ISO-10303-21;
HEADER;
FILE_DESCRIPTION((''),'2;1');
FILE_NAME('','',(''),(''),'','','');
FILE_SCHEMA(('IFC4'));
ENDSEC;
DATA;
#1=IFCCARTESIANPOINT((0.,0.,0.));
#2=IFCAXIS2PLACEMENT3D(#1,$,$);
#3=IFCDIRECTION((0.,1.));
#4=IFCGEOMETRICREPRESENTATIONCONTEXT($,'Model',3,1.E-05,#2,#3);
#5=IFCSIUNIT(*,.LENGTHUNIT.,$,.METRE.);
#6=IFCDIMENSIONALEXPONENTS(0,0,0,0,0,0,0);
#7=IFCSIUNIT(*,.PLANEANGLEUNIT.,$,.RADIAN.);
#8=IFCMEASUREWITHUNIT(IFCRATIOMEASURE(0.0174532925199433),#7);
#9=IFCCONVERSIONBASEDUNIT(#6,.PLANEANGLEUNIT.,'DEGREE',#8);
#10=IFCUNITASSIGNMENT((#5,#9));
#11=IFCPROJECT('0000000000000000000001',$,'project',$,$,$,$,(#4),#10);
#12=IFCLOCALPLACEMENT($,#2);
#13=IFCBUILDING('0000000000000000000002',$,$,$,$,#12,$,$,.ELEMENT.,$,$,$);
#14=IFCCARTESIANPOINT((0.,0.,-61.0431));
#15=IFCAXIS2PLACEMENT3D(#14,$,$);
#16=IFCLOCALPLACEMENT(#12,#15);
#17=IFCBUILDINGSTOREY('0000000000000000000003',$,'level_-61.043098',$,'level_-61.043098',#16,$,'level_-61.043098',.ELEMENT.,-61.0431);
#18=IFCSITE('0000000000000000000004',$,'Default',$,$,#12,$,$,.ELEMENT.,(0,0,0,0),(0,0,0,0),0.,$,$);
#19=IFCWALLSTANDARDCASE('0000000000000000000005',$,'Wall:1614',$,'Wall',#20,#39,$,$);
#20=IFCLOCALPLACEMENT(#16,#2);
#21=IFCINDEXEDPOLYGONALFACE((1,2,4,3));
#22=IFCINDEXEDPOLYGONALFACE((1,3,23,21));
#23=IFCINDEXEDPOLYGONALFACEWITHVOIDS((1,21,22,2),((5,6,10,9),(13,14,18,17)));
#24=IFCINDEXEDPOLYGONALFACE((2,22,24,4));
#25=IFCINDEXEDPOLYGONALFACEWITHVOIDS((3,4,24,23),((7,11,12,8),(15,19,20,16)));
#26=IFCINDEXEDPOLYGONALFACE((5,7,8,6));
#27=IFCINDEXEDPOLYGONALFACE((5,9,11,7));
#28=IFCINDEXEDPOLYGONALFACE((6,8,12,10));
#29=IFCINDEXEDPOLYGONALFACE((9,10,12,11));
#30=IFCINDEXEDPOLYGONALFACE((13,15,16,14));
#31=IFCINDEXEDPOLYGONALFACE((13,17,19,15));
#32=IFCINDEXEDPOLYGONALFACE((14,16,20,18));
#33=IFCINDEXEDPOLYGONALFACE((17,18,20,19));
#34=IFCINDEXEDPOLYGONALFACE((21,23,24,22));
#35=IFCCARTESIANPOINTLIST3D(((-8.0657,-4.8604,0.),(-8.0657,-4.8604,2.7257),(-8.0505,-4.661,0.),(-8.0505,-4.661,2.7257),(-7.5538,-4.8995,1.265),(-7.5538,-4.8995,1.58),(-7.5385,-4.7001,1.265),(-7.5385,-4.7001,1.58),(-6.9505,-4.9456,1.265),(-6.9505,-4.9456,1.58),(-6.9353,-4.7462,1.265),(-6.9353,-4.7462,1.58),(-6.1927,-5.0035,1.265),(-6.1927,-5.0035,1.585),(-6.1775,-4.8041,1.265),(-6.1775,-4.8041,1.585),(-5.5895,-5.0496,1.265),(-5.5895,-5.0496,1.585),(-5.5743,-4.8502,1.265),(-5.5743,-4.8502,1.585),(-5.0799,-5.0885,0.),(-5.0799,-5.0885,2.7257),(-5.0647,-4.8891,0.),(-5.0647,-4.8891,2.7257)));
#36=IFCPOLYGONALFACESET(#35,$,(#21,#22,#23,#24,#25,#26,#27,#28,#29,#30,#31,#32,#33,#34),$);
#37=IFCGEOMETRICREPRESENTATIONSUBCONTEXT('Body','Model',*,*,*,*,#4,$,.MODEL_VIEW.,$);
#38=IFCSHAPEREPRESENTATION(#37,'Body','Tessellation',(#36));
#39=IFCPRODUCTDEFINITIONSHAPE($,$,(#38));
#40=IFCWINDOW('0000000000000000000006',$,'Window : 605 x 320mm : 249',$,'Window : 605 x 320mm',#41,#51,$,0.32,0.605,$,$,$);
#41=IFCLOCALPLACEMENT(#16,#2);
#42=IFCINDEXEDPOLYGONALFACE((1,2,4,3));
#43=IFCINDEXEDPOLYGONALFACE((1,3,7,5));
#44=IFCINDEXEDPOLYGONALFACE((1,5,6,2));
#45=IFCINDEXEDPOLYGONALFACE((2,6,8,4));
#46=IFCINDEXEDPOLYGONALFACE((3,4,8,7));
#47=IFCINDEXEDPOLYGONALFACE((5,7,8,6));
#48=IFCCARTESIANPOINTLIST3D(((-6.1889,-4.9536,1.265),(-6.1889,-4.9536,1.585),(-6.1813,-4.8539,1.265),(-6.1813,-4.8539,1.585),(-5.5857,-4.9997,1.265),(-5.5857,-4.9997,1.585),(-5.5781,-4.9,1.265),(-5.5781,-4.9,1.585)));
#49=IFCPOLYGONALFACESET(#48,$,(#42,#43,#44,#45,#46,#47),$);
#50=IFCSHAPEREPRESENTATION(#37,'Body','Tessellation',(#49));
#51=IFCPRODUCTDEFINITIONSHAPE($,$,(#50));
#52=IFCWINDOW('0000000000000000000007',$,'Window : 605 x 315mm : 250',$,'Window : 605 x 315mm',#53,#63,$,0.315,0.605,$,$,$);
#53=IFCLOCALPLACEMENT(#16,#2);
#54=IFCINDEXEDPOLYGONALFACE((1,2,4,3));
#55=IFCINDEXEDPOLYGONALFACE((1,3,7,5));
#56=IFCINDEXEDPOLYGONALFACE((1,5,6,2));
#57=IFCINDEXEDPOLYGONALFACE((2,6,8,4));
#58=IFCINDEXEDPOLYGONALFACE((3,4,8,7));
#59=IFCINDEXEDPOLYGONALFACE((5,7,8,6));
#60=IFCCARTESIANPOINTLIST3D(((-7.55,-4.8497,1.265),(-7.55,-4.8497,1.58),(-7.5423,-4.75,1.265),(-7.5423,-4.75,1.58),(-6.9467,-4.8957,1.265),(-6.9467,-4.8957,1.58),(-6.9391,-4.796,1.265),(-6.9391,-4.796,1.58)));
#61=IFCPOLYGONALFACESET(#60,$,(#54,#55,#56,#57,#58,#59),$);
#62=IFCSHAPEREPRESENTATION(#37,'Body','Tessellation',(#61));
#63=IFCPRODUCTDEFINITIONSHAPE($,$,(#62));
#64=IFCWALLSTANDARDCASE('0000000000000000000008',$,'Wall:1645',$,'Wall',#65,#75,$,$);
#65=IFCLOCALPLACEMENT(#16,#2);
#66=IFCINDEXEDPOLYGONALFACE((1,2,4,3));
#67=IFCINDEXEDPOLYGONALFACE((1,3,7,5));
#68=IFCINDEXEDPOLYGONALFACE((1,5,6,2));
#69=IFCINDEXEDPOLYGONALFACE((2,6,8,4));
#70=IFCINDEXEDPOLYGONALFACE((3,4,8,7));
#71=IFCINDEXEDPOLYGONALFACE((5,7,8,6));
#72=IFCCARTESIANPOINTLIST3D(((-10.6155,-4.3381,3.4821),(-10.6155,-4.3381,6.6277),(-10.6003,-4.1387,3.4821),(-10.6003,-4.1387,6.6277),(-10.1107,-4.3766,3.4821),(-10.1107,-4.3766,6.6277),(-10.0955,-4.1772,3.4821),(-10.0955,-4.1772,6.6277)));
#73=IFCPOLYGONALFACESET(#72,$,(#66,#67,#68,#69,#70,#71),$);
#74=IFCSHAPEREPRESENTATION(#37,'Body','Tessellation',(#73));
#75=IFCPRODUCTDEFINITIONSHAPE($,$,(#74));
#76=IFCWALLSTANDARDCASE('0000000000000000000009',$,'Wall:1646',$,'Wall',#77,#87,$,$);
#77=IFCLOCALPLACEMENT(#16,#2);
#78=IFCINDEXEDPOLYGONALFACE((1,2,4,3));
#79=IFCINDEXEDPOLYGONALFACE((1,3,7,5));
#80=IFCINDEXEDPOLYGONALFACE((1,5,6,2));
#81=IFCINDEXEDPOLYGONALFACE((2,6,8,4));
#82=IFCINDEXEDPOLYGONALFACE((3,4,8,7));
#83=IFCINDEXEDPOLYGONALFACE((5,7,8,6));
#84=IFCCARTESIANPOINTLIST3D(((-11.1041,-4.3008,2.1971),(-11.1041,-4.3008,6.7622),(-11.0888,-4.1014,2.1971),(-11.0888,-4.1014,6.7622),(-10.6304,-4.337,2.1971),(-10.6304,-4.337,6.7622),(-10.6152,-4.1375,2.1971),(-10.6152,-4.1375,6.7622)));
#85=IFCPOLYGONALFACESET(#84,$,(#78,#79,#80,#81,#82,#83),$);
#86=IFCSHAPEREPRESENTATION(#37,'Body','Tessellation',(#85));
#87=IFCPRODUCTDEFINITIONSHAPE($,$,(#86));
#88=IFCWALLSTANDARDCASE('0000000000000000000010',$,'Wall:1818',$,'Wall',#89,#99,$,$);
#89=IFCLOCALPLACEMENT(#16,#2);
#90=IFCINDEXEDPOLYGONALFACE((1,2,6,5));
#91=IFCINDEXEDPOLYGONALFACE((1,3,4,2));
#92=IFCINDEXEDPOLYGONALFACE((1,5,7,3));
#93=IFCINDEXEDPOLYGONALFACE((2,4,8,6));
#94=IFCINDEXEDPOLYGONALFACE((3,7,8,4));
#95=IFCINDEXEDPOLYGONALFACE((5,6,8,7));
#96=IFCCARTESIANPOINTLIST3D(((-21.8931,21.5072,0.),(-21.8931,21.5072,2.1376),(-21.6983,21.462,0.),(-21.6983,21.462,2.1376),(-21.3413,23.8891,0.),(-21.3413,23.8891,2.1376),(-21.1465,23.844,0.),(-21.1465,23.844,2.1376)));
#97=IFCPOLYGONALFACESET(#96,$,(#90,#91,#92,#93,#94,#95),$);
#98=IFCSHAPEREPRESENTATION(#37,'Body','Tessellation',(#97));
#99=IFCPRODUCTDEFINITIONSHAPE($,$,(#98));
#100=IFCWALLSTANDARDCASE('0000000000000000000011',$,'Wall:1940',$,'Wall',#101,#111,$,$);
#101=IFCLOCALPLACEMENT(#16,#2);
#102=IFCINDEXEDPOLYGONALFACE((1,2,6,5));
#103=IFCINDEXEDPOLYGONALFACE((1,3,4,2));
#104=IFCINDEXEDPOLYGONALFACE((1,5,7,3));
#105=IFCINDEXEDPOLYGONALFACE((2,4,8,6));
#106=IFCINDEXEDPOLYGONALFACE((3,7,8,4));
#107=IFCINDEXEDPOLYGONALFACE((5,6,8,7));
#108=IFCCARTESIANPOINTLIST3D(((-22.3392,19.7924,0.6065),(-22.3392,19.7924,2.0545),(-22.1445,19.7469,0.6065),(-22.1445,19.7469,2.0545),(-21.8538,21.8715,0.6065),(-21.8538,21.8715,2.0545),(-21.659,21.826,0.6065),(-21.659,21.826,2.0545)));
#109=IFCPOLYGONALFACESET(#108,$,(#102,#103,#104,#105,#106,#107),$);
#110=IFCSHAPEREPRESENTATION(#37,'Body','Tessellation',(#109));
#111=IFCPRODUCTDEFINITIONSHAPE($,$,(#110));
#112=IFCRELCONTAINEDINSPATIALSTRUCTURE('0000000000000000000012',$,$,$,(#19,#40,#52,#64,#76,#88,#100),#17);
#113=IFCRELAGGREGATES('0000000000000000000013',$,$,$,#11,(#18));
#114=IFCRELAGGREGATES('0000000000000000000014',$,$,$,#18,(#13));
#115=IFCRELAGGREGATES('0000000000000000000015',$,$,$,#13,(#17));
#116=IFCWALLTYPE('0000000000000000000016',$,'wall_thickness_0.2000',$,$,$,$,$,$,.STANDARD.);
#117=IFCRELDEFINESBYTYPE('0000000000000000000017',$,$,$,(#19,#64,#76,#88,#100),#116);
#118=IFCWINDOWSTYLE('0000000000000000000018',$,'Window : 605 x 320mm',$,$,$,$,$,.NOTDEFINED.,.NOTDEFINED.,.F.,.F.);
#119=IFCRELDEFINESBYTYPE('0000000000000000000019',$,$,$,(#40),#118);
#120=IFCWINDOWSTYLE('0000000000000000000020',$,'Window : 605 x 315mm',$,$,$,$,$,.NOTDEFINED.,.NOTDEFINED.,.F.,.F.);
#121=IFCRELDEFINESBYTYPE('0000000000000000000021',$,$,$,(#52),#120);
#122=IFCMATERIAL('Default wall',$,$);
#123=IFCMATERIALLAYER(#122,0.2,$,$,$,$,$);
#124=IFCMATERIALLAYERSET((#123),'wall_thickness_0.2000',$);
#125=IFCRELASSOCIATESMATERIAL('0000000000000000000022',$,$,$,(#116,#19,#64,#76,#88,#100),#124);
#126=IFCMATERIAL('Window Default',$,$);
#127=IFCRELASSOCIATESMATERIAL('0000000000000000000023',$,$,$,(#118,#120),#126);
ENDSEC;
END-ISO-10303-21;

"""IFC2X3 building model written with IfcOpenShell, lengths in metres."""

from ifc_helpers import new_model, entity, si_unit, converted_unit, direction, frame, frame_2d, origin, origin_2d_with_axis, place, context, subcontext, project, spatial, polyline, rectangle, outline, extrude, source, transform, mapped, material, layer, layer_set, layer_usage, type_object, type_shapes, element, fill, save


model = new_model("IFC2X3")

# Units and contexts
model_context = context("Model", 3, precision=1e-05, world=origin(), true_north=direction((0.0, 1.0)))
body_context = subcontext(model_context, "Body", "Model", "MODEL_VIEW")
ifc_project = project(units=[si_unit("LENGTHUNIT", "METRE"), converted_unit("PLANEANGLEUNIT", "DEGREE", entity("IfcRatioMeasure", 0.0174532925199433), si_unit("PLANEANGLEUNIT", "RADIAN"), dimensions=[0, 0, 0, 0, 0, 0, 0])], contexts=[model_context])

# Site, building, storey
placement_1 = place(None, origin())
site = spatial("IfcSite", under=ifc_project, at=placement_1, Name="Default", CompositionType="ELEMENT", RefLatitude=(0, 0, 0, 0), RefLongitude=(0, 0, 0, 0), RefElevation=0.0)
building = spatial("IfcBuilding", under=site, at=placement_1, CompositionType="ELEMENT")
storey_placement = place(placement_1, frame((0.0, 0.0, -61.0431)))
storey = spatial("IfcBuildingStorey", under=building, at=storey_placement, Name="level_-61.043098", ObjectType="level_-61.043098", LongName="level_-61.043098", CompositionType="ELEMENT", Elevation=-61.0431)

# Shared definitions
ifc_material_1 = material(Name="Default wall")
ifc_layer = layer(ifc_material_1, 0.2)
ifc_layer_set = layer_set([ifc_layer], Name="wall_thickness_0.2000")
ifc_layer_usage = layer_usage(ifc_layer_set, "AXIS2", "POSITIVE", -0.1)
wall_type = type_object("IfcWallType", Name="wall_thickness_0.2000", PredefinedType="STANDARD", material=ifc_layer_set)

# Shared definitions
ifc_material_2 = material(Name="Window Default")

# Wall, openings, windows
wall_1_placement = place(storey_placement, frame((-5.0723, -4.9888, 0.0), z_axis=(0.0, 0.0, 1.0), x_axis=(-0.997095, 0.07617, 0.0)))
wall_1 = element("IfcWallStandardCase", 1, at=wall_1_placement, inside=storey, type_object=wall_type, material=ifc_layer_usage, Name="Wall:1614", ObjectType="Wall", context=body_context, shape_type="SweptSolid", body=[
    extrude(outline(polyline([(2.9945, -0.1), (2.9945, 0.1), (0.0, 0.1), (0.0, -0.1), (2.9945, -0.1)])), origin(), (0.0, 0.0, 1.0), 2.7257),
])
opening_1_placement = place(wall_1_placement, frame((0.511, -0.1, 1.265)))
opening_1 = element("IfcOpeningElement", 2, at=opening_1_placement, cuts=wall_1, ObjectType="Opening", context=body_context, shape_type="SweptSolid", body=[
    extrude(rectangle(XDim=0.605, YDim=0.32, at=frame_2d((0.16, 0.3025), x_axis=(0.0, 1.0))), frame((0.0, 0.0, 0.0), z_axis=(0.0, 1.0, 0.0), x_axis=(0.0, 0.0, 1.0)), (0.0, 0.0, 1.0), 0.2),
])
opening_2_placement = place(wall_1_placement, frame((1.876, -0.1, 1.265)))
opening_2 = element("IfcOpeningElement", 3, at=opening_2_placement, cuts=wall_1, ObjectType="Opening", context=body_context, shape_type="SweptSolid", body=[
    extrude(rectangle(XDim=0.605, YDim=0.315, at=frame_2d((0.1575, 0.3025), x_axis=(0.0, 1.0))), frame((0.0, 0.0, 0.0), z_axis=(0.0, 1.0, 0.0), x_axis=(0.0, 0.0, 1.0)), (0.0, 0.0, 1.0), 0.2),
])
window_style_1 = type_object("IfcWindowStyle", Name="Window : 605 x 320mm", ConstructionType="NOTDEFINED", OperationType="NOTDEFINED", ParameterTakesPrecedence=False, Sizeable=False, material=ifc_material_2)
shared_shape_1 = source(origin(), body_context, "Body", "SweptSolid", [
    extrude(rectangle(XDim=0.1, YDim=0.605, at=origin_2d_with_axis()), frame((0.3025, 0.1, 0.0), z_axis=(0.0, 0.0, 1.0), x_axis=(0.0, 1.0, 0.0)), (0.0, 0.0, 1.0), 0.32),
])
type_shapes(window_style_1, [shared_shape_1])
window_1_placement = place(opening_1_placement, origin())
window_1 = element("IfcWindow", 4, at=window_1_placement, inside=storey, type_object=window_style_1, Name="Window : 605 x 320mm : 249", ObjectType="Window : 605 x 320mm", OverallHeight=0.32, OverallWidth=0.605, context=body_context, shape_type="MappedRepresentation", body=[
    mapped(shared_shape_1, transform((0.0, 0.0, 0.0), scale=1.0)),
])
fill(opening_1, window_1)
window_style_2 = type_object("IfcWindowStyle", Name="Window : 605 x 315mm", ConstructionType="NOTDEFINED", OperationType="NOTDEFINED", ParameterTakesPrecedence=False, Sizeable=False, material=ifc_material_2)
shared_shape_2 = source(origin(), body_context, "Body", "SweptSolid", [
    extrude(rectangle(XDim=0.1, YDim=0.605, at=origin_2d_with_axis()), frame((0.3025, 0.1, 0.0), z_axis=(0.0, 0.0, 1.0), x_axis=(0.0, 1.0, 0.0)), (0.0, 0.0, 1.0), 0.315),
])
type_shapes(window_style_2, [shared_shape_2])
window_2_placement = place(opening_2_placement, origin())
window_2 = element("IfcWindow", 5, at=window_2_placement, inside=storey, type_object=window_style_2, Name="Window : 605 x 315mm : 250", ObjectType="Window : 605 x 315mm", OverallHeight=0.315, OverallWidth=0.605, context=body_context, shape_type="MappedRepresentation", body=[
    mapped(shared_shape_2, transform((0.0, 0.0, 0.0), scale=1.0)),
])
fill(opening_2, window_2)

# Walls
placement_2 = place(placement_1, frame((0.0, 0.0, -57.561)))
wall_2_placement = place(placement_2, frame((-10.6079, -4.2384, 0.0), z_axis=(0.0, 0.0, 1.0), x_axis=(0.997099, -0.076114, 0.0)))
element("IfcWallStandardCase", 6, at=wall_2_placement, inside=storey, type_object=wall_type, material=ifc_layer_usage, Name="Wall:1645", ObjectType="Wall", context=body_context, shape_type="SweptSolid", body=[
    extrude(outline(polyline([(0.5062, -0.1), (0.5062, 0.1), (0.0, 0.1), (0.0, -0.1), (0.5062, -0.1)])), origin(), (0.0, 0.0, 1.0), 3.1456),
])
placement_3 = place(placement_1, frame((0.0, 0.0, -58.846)))
wall_3_placement = place(placement_3, frame((-11.0964, -4.2011, 0.0), z_axis=(0.0, 0.0, 1.0), x_axis=(0.997099, -0.076115, 0.0)))
element("IfcWallStandardCase", 7, at=wall_3_placement, inside=storey, type_object=wall_type, material=ifc_layer_usage, Name="Wall:1646", ObjectType="Wall", context=body_context, shape_type="SweptSolid", body=[
    extrude(outline(polyline([(0.475, -0.1), (0.475, 0.1), (0.0, 0.1), (0.0, -0.1), (0.475, -0.1)])), origin(), (0.0, 0.0, 1.0), 4.5651),
])
wall_4_placement = place(storey_placement, frame((-21.2439, 23.8665, 0.0), z_axis=(0.0, 0.0, 1.0), x_axis=(-0.225691, -0.974199, 0.0)))
element("IfcWallStandardCase", 8, at=wall_4_placement, inside=storey, type_object=wall_type, material=ifc_layer_usage, Name="Wall:1818", ObjectType="Wall", context=body_context, shape_type="SweptSolid", body=[
    extrude(outline(polyline([(2.445, -0.1), (2.445, 0.1), (0.0, 0.1), (0.0, -0.1), (2.445, -0.1)])), origin(), (0.0, 0.0, 1.0), 2.1376),
])
placement_4 = place(placement_1, frame((0.0, 0.0, -60.4366)))
wall_5_placement = place(placement_4, frame((-21.7564, 21.8488, 0.0), z_axis=(0.0, 0.0, 1.0), x_axis=(-0.227377, -0.973807, 0.0)))
element("IfcWallStandardCase", 9, at=wall_5_placement, inside=storey, type_object=wall_type, material=ifc_layer_usage, Name="Wall:1940", ObjectType="Wall", context=body_context, shape_type="SweptSolid", body=[
    extrude(outline(polyline([(2.135, -0.1), (2.135, 0.1), (0.0, 0.1), (0.0, -0.1), (2.135, -0.1)])), origin(), (0.0, 0.0, 1.0), 1.4479),
])

save(model, "model.ifc")
